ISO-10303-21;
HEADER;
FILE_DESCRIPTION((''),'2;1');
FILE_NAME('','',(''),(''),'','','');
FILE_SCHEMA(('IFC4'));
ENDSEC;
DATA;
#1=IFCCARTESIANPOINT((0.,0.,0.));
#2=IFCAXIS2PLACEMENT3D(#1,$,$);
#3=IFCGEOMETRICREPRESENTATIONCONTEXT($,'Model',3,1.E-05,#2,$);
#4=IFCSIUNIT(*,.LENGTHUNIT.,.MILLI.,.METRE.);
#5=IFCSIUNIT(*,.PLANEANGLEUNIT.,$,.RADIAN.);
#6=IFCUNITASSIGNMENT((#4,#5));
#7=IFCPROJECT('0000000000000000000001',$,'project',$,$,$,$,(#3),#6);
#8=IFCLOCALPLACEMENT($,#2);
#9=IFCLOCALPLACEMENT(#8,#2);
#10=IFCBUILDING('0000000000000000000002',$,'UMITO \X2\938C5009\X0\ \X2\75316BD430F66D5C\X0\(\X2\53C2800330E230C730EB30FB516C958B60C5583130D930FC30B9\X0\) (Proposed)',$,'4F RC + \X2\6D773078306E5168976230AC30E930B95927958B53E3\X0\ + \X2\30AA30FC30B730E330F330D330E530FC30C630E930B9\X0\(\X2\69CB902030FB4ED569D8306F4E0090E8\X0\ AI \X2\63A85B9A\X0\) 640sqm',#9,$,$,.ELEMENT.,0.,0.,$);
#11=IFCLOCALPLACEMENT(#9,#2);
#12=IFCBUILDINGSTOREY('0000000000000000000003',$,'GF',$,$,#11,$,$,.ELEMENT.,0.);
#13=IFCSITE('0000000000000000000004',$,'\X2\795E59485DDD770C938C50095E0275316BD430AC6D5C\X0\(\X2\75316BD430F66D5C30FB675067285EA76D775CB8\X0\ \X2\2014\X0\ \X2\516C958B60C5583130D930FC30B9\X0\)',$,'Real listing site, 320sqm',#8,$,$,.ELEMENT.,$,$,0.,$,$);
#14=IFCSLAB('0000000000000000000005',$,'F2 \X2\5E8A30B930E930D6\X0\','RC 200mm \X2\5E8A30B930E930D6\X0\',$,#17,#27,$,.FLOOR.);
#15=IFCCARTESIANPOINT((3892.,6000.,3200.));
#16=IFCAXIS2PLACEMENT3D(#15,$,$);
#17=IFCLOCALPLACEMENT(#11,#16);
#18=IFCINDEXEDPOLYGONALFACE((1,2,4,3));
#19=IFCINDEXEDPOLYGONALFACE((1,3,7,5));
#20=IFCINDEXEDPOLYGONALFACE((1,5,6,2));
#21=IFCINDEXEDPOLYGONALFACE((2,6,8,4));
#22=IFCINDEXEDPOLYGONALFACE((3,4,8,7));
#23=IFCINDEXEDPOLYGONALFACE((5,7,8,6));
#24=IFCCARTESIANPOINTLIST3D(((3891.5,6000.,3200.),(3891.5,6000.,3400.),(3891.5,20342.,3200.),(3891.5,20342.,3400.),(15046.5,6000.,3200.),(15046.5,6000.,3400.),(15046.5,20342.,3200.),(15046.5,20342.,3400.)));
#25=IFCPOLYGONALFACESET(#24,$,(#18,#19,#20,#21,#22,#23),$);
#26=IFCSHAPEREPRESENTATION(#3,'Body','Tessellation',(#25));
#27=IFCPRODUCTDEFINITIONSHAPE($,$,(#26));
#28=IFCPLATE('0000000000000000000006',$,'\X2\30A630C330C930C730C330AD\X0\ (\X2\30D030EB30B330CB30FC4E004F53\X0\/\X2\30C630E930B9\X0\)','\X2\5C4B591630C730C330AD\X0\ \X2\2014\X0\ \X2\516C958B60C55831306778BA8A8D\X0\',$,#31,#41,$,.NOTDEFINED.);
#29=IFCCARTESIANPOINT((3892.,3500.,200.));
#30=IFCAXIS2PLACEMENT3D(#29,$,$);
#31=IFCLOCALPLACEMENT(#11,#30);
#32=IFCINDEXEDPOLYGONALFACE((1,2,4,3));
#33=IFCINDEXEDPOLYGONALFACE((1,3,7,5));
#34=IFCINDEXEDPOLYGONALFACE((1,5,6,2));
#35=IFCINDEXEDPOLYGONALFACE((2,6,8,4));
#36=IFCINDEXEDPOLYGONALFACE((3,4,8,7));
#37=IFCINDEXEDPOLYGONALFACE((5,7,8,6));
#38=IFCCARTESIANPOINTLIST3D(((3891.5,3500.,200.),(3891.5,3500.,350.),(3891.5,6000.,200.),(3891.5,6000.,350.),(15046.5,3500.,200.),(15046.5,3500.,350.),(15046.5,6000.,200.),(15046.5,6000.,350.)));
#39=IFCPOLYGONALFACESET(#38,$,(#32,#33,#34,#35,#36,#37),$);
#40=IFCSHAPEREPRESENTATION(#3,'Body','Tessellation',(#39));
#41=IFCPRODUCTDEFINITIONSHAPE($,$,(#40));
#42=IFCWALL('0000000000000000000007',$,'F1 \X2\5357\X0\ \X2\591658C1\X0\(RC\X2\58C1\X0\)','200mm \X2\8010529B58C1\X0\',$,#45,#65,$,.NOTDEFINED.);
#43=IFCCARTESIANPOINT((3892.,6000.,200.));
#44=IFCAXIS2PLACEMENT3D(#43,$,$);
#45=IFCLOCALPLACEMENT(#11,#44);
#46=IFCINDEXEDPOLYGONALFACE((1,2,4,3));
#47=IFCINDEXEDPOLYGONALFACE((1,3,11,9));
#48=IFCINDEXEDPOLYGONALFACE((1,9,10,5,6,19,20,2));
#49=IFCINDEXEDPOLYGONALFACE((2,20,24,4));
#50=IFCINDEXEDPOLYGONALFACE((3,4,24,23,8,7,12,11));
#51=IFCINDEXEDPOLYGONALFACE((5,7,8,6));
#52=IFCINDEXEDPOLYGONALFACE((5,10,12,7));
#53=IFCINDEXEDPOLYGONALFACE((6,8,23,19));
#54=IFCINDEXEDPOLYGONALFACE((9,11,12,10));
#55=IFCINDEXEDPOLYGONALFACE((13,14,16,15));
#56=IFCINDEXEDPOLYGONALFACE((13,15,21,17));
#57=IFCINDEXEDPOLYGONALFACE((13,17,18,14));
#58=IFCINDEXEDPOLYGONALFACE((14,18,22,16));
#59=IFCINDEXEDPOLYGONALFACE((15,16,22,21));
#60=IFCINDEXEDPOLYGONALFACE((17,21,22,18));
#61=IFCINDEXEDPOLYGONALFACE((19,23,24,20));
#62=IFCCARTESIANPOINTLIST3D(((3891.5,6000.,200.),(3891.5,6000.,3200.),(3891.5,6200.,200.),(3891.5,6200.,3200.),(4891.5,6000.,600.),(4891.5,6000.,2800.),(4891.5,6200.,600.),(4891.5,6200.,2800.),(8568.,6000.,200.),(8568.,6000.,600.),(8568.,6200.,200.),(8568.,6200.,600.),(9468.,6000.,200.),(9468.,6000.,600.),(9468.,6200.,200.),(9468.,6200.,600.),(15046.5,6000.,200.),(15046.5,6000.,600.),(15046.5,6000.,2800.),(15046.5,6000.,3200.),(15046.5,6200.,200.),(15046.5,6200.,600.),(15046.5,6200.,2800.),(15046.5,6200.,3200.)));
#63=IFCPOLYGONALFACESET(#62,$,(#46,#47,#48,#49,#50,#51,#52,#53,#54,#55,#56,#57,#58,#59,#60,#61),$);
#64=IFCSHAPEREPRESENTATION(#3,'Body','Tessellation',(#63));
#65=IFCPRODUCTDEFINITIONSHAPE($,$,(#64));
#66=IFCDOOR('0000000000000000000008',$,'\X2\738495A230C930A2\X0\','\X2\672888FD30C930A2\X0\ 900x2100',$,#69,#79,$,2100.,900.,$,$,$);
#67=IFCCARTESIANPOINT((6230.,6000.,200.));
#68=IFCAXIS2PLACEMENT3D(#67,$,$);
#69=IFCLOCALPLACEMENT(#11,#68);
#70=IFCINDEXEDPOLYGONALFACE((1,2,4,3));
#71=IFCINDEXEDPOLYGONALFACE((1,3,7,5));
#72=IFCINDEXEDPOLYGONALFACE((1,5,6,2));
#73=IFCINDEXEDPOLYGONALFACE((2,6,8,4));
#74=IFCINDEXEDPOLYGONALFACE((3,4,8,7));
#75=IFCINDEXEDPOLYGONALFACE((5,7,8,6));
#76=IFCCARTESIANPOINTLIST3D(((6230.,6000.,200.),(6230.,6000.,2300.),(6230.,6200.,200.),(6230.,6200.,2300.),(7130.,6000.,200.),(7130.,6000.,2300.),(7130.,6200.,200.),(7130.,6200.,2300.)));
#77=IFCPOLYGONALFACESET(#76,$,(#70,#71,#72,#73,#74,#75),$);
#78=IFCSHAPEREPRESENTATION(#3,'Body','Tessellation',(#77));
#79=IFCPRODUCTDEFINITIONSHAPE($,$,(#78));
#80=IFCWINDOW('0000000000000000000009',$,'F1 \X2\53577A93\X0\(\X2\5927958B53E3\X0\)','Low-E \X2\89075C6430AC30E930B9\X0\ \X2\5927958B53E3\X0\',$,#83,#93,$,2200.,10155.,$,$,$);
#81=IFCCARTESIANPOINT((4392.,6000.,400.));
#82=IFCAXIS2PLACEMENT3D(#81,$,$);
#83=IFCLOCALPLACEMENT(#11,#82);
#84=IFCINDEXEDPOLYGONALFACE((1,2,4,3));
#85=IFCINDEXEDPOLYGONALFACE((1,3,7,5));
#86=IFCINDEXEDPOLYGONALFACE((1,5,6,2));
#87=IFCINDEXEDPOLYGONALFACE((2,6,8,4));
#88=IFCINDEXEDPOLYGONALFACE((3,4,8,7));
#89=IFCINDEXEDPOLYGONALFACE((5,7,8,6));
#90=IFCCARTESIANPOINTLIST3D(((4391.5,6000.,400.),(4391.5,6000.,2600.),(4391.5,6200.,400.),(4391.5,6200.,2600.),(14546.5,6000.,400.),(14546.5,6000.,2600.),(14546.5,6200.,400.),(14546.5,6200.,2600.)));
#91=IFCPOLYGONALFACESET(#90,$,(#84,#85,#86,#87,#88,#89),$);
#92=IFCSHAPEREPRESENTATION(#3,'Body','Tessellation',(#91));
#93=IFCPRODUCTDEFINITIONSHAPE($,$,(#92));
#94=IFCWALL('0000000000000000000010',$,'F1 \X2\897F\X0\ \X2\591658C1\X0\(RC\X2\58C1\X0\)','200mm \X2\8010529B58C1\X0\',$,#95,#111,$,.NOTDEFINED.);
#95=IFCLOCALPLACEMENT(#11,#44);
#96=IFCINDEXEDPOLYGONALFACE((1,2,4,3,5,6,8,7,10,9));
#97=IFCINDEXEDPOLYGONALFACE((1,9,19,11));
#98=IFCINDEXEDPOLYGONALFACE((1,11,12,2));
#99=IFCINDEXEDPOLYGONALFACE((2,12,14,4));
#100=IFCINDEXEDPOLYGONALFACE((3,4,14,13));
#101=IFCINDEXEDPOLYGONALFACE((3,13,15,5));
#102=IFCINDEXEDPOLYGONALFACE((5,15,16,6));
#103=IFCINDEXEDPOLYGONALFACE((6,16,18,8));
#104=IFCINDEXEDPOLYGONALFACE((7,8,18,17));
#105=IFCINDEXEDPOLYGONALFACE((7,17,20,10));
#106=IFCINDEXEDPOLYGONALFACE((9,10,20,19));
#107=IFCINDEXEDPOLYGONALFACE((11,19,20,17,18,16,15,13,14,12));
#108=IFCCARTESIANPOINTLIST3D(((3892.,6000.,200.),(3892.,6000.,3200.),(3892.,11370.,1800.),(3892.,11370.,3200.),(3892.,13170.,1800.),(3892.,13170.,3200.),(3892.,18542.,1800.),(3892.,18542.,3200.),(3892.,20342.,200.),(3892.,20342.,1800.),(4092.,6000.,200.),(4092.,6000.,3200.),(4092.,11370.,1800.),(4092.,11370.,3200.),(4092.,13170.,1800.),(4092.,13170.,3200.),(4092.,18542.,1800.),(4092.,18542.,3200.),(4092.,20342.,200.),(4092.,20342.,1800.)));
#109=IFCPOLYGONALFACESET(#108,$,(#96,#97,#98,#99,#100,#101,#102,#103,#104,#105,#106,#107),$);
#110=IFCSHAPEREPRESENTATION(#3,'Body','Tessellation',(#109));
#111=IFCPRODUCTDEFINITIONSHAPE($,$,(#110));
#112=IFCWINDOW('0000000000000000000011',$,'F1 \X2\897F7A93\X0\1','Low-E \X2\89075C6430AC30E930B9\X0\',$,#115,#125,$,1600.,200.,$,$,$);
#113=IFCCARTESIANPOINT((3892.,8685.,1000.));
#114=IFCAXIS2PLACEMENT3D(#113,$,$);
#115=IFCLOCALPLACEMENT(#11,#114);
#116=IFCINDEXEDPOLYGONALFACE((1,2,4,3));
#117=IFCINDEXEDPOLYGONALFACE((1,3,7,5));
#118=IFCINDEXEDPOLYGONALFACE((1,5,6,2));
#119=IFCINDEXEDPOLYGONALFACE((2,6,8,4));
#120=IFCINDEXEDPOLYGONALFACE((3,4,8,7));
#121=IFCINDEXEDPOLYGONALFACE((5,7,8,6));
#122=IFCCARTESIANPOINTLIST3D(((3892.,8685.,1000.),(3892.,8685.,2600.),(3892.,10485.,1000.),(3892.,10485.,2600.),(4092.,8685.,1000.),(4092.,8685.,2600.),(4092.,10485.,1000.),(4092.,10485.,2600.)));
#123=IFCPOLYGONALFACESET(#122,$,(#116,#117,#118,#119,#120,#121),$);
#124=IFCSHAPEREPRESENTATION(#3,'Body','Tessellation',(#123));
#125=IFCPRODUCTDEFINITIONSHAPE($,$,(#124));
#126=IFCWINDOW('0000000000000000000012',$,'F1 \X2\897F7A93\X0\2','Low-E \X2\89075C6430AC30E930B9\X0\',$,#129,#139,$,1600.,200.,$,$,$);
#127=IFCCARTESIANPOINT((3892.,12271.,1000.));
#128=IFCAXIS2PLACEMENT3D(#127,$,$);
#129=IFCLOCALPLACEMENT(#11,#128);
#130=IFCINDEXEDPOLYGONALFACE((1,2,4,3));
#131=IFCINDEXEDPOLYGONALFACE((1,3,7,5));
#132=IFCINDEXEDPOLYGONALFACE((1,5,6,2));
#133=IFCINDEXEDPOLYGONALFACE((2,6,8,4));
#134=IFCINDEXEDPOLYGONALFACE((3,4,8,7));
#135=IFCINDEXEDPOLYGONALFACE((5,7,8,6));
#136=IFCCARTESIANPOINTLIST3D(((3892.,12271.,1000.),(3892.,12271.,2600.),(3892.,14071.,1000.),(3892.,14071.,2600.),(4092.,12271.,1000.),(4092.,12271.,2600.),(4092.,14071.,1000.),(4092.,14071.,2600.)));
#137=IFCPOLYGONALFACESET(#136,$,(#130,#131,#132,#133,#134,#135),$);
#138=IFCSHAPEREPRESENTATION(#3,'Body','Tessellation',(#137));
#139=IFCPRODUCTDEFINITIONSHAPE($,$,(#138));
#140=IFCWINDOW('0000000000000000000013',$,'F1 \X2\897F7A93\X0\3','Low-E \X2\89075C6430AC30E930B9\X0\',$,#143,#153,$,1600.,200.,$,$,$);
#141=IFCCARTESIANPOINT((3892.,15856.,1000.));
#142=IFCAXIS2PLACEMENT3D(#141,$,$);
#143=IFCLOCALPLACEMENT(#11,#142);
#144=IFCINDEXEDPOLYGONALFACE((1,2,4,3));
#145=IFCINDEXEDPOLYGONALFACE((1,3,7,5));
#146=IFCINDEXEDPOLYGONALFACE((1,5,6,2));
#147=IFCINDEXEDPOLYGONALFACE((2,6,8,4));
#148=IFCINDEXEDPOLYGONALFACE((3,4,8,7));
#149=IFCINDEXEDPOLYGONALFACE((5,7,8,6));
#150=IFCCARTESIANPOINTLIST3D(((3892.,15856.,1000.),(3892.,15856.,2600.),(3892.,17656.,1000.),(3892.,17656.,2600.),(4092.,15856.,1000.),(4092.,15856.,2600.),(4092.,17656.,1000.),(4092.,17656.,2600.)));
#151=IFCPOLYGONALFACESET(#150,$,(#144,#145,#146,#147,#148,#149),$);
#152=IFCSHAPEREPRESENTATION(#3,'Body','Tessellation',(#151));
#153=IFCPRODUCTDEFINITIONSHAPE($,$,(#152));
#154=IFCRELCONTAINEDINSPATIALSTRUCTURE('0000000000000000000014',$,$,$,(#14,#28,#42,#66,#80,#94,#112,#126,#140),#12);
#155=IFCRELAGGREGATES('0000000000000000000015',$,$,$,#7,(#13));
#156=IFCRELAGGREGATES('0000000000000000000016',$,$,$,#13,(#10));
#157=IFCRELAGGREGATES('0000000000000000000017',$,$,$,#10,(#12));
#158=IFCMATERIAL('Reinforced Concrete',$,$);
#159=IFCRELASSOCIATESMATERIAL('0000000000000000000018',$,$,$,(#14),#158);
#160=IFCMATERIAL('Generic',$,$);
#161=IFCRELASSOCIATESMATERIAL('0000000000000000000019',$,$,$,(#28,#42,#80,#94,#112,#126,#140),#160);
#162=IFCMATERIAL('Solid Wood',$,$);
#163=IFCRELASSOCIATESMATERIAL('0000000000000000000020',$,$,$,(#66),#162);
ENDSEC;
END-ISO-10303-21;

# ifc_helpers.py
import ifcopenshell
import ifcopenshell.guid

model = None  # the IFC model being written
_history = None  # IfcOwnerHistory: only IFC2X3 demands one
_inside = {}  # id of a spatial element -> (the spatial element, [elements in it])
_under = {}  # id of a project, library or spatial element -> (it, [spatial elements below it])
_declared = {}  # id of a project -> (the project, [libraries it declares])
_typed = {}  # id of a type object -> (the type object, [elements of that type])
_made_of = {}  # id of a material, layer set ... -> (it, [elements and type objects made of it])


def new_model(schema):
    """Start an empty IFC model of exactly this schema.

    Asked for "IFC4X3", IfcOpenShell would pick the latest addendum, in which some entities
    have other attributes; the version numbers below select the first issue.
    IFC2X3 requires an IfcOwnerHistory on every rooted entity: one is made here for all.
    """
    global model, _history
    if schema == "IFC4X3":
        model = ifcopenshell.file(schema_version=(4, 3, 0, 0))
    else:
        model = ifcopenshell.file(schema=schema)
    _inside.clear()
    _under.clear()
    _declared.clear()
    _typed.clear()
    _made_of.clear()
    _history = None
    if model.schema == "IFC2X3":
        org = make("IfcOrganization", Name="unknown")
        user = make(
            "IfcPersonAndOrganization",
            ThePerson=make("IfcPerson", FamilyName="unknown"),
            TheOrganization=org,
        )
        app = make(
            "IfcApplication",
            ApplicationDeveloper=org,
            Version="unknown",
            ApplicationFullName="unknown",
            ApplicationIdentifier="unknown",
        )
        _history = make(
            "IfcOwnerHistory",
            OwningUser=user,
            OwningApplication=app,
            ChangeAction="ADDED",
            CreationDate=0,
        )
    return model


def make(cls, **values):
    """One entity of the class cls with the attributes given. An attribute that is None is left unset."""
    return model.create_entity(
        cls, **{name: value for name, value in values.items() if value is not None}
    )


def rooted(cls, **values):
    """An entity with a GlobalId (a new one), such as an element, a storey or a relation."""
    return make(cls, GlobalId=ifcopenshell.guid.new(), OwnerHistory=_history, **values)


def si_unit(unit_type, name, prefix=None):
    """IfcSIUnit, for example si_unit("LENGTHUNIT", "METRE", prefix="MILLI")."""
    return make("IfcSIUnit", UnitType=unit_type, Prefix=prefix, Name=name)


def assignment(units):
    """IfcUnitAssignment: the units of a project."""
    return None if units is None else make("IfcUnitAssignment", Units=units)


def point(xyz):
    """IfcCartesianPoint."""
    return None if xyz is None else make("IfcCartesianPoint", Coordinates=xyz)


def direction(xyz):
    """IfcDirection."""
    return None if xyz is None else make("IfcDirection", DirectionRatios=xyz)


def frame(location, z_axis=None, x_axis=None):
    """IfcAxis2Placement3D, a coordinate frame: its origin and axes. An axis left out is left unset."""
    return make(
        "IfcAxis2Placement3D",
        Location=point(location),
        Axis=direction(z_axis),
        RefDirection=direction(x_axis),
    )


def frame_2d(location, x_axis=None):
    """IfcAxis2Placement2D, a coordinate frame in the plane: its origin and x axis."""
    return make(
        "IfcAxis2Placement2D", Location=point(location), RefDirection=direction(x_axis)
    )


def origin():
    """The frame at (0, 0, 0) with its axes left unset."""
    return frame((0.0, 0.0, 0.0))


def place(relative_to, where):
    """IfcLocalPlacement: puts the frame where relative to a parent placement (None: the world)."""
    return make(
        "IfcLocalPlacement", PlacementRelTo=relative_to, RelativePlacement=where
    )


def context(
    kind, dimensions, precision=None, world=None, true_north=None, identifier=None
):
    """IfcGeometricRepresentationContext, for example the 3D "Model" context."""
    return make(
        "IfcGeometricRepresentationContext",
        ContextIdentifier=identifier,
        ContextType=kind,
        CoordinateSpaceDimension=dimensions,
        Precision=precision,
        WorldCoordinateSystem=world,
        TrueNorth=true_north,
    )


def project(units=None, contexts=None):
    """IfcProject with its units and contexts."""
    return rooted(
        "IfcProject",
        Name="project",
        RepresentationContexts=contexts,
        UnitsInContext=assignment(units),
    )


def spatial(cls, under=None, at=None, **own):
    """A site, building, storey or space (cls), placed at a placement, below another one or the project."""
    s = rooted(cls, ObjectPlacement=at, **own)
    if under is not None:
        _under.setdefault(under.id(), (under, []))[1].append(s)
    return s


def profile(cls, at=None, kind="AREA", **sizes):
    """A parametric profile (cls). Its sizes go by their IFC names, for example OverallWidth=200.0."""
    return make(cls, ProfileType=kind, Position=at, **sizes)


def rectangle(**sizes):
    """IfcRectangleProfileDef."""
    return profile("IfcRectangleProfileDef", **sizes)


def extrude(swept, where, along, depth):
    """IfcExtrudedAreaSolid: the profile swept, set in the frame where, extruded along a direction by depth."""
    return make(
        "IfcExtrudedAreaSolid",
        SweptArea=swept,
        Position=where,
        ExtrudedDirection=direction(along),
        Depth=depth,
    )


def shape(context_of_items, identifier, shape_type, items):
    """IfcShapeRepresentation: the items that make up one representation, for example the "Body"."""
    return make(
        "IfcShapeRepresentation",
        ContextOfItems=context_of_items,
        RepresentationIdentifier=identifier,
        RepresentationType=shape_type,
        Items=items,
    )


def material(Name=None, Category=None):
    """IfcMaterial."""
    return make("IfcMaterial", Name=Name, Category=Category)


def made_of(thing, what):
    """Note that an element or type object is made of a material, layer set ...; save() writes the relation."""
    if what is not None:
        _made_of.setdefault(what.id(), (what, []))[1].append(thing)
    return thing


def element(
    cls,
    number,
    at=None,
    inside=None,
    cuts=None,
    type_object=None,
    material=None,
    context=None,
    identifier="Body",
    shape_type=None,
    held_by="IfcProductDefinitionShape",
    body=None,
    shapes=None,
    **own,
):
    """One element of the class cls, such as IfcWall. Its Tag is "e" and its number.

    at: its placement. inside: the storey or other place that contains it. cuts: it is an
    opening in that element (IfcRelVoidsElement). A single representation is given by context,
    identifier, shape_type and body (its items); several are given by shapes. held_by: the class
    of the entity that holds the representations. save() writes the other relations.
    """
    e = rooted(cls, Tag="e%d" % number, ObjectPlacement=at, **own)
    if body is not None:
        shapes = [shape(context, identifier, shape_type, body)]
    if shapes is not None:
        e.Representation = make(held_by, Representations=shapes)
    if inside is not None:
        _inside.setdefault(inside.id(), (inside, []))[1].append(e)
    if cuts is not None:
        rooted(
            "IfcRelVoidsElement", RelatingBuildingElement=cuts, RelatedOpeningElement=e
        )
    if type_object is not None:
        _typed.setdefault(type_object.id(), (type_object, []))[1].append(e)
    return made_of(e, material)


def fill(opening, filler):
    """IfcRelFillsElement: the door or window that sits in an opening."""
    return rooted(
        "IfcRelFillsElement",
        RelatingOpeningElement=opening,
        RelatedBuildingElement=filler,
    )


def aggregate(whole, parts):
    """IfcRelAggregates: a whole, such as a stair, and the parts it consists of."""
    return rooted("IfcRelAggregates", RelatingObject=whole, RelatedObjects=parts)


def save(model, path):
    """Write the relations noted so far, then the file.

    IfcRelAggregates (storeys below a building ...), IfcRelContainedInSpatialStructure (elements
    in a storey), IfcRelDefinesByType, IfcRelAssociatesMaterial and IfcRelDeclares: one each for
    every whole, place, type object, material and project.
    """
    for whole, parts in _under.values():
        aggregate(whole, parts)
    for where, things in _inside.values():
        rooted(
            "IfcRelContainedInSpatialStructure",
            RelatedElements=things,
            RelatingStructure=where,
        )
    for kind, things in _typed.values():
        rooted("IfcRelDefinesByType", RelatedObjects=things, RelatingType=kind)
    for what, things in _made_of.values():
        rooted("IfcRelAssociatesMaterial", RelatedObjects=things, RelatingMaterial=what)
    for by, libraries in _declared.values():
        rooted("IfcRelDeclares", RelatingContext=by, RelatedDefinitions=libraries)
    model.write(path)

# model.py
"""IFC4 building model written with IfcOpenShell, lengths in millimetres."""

from ifc_helpers import new_model, si_unit, frame, frame_2d, origin, place, context, project, spatial, rectangle, extrude, material, element, fill, save


model = new_model("IFC4")

# Units and contexts
model_context = context("Model", 3, precision=1e-05, world=origin())
ifc_project = project(units=[si_unit("LENGTHUNIT", "METRE", prefix="MILLI"), si_unit("PLANEANGLEUNIT", "RADIAN")], contexts=[model_context])

# Site, building, storey
site_placement = place(None, origin())
site = spatial("IfcSite", under=ifc_project, at=site_placement, Name="神奈川県鎌倉市由比ガ浜(由比ヶ浜・材木座海岸 — 公開情報ベース)", ObjectType="Real listing site, 320sqm", CompositionType="ELEMENT", RefElevation=0.0)
building_placement = place(site_placement, origin())
building = spatial("IfcBuilding", under=site, at=building_placement, Name="UMITO 鎌倉 由比ヶ浜(参考モデル・公開情報ベース) (Proposed)", ObjectType="4F RC + 海への全面ガラス大開口 + オーシャンビューテラス(構造・仕様は一部 AI 推定) 640sqm", CompositionType="ELEMENT", ElevationOfRefHeight=0.0, ElevationOfTerrain=0.0)
storey_placement = place(building_placement, origin())
storey = spatial("IfcBuildingStorey", under=building, at=storey_placement, Name="GF", CompositionType="ELEMENT", Elevation=0.0)

# Slab
ifc_material_1 = material(Name="Reinforced Concrete")
slab_1_placement = place(storey_placement, frame((3892.0, 6000.0, 3200.0)))
element("IfcSlab", 1, at=slab_1_placement, inside=storey, material=ifc_material_1, Name="F2 床スラブ", Description="RC 200mm 床スラブ", PredefinedType="FLOOR", context=model_context, shape_type="SweptSolid", body=[
    extrude(rectangle(XDim=11155.0, YDim=14342.0, at=frame_2d((5577.0, 7171.0))), frame((3892.0, 6000.0, 3200.0)), (0.0, 0.0, 1.0), 200.0),
])

# Plate
ifc_material_2 = material(Name="Generic")
plate_placement = place(storey_placement, frame((3892.0, 3500.0, 200.0)))
element("IfcPlate", 2, at=plate_placement, inside=storey, material=ifc_material_2, Name="ウッドデッキ (バルコニー一体/テラス)", Description="屋外デッキ — 公開情報で確認", PredefinedType="NOTDEFINED", context=model_context, shape_type="SweptSolid", body=[
    extrude(rectangle(XDim=11155.0, YDim=2500.0, at=frame_2d((5577.0, 1250.0))), frame((3892.0, 3500.0, 200.0)), (0.0, 0.0, 1.0), 150.0),
])

# Wall, openings, door, window
wall_1_placement = place(storey_placement, frame((3892.0, 6000.0, 200.0)))
wall_1 = element("IfcWall", 3, at=wall_1_placement, inside=storey, material=ifc_material_2, Name="F1 南 外壁(RC壁)", Description="200mm 耐力壁", PredefinedType="NOTDEFINED", context=model_context, shape_type="SweptSolid", body=[
    extrude(rectangle(XDim=11155.0, YDim=200.0, at=frame_2d((5577.0, 100.0))), frame((3892.0, 6000.0, 200.0)), (0.0, 0.0, 1.0), 3000.0),
])
opening_1_placement = place(storey_placement, frame((6230.0, 6000.0, 200.0)))
opening_1 = element("IfcOpeningElement", 4, at=opening_1_placement, cuts=wall_1, PredefinedType="NOTDEFINED", context=model_context, shape_type="SweptSolid", body=[
    extrude(rectangle(XDim=900.0, YDim=200.0, at=frame_2d((450.0, 100.0))), frame((6230.0, 6000.0, 200.0)), (0.0, 0.0, 1.0), 2100.0),
])
opening_2_placement = place(storey_placement, frame((4392.0, 6000.0, 400.0)))
opening_2 = element("IfcOpeningElement", 5, at=opening_2_placement, cuts=wall_1, PredefinedType="NOTDEFINED", context=model_context, shape_type="SweptSolid", body=[
    extrude(rectangle(XDim=10155.0, YDim=200.0, at=frame_2d((5077.0, 100.0))), frame((4392.0, 6000.0, 400.0)), (0.0, 0.0, 1.0), 2200.0),
])
ifc_material_3 = material(Name="Solid Wood")
door_placement = place(storey_placement, frame((6230.0, 6000.0, 200.0)))
door = element("IfcDoor", 6, at=door_placement, inside=storey, material=ifc_material_3, Name="玄関ドア", Description="木製ドア 900x2100", OverallHeight=2100.0, OverallWidth=900.0, context=model_context, shape_type="SweptSolid", body=[
    extrude(rectangle(XDim=900.0, YDim=200.0, at=frame_2d((450.0, 100.0))), frame((6230.0, 6000.0, 200.0)), (0.0, 0.0, 1.0), 2100.0),
])
fill(opening_1, door)
window_1_placement = place(storey_placement, frame((4392.0, 6000.0, 400.0)))
window_1 = element("IfcWindow", 7, at=window_1_placement, inside=storey, material=ifc_material_2, Name="F1 南窓(大開口)", Description="Low-E 複層ガラス 大開口", OverallHeight=2200.0, OverallWidth=10155.0, context=model_context, shape_type="SweptSolid", body=[
    extrude(rectangle(XDim=10155.0, YDim=200.0, at=frame_2d((5077.0, 100.0))), frame((4392.0, 6000.0, 400.0)), (0.0, 0.0, 1.0), 2200.0),
])
fill(opening_2, window_1)

# Wall, openings, windows
wall_2_placement = place(storey_placement, frame((3892.0, 6000.0, 200.0)))
wall_2 = element("IfcWall", 8, at=wall_2_placement, inside=storey, material=ifc_material_2, Name="F1 西 外壁(RC壁)", Description="200mm 耐力壁", PredefinedType="NOTDEFINED", context=model_context, shape_type="SweptSolid", body=[
    extrude(rectangle(XDim=200.0, YDim=14342.0, at=frame_2d((100.0, 7171.0))), frame((3892.0, 6000.0, 200.0)), (0.0, 0.0, 1.0), 3000.0),
])
opening_3_placement = place(storey_placement, frame((3892.0, 8685.0, 1000.0)))
opening_3 = element("IfcOpeningElement", 9, at=opening_3_placement, cuts=wall_2, PredefinedType="NOTDEFINED", context=model_context, shape_type="SweptSolid", body=[
    extrude(rectangle(XDim=200.0, YDim=1800.0, at=frame_2d((100.0, 900.0))), frame((3892.0, 8685.0, 1000.0)), (0.0, 0.0, 1.0), 1600.0),
])
opening_4_placement = place(storey_placement, frame((3892.0, 12271.0, 1000.0)))
opening_4 = element("IfcOpeningElement", 10, at=opening_4_placement, cuts=wall_2, PredefinedType="NOTDEFINED", context=model_context, shape_type="SweptSolid", body=[
    extrude(rectangle(XDim=200.0, YDim=1800.0, at=frame_2d((100.0, 900.0))), frame((3892.0, 12271.0, 1000.0)), (0.0, 0.0, 1.0), 1600.0),
])
opening_5_placement = place(storey_placement, frame((3892.0, 15856.0, 1000.0)))
opening_5 = element("IfcOpeningElement", 11, at=opening_5_placement, cuts=wall_2, PredefinedType="NOTDEFINED", context=model_context, shape_type="SweptSolid", body=[
    extrude(rectangle(XDim=200.0, YDim=1800.0, at=frame_2d((100.0, 900.0))), frame((3892.0, 15856.0, 1000.0)), (0.0, 0.0, 1.0), 1600.0),
])
window_2_placement = place(storey_placement, frame((3892.0, 8685.0, 1000.0)))
window_2 = element("IfcWindow", 12, at=window_2_placement, inside=storey, material=ifc_material_2, Name="F1 西窓1", Description="Low-E 複層ガラス", OverallHeight=1600.0, OverallWidth=200.0, context=model_context, shape_type="SweptSolid", body=[
    extrude(rectangle(XDim=200.0, YDim=1800.0, at=frame_2d((100.0, 900.0))), frame((3892.0, 8685.0, 1000.0)), (0.0, 0.0, 1.0), 1600.0),
])
fill(opening_3, window_2)
window_3_placement = place(storey_placement, frame((3892.0, 12271.0, 1000.0)))
window_3 = element("IfcWindow", 13, at=window_3_placement, inside=storey, material=ifc_material_2, Name="F1 西窓2", Description="Low-E 複層ガラス", OverallHeight=1600.0, OverallWidth=200.0, context=model_context, shape_type="SweptSolid", body=[
    extrude(rectangle(XDim=200.0, YDim=1800.0, at=frame_2d((100.0, 900.0))), frame((3892.0, 12271.0, 1000.0)), (0.0, 0.0, 1.0), 1600.0),
])
fill(opening_4, window_3)
window_4_placement = place(storey_placement, frame((3892.0, 15856.0, 1000.0)))
window_4 = element("IfcWindow", 14, at=window_4_placement, inside=storey, material=ifc_material_2, Name="F1 西窓3", Description="Low-E 複層ガラス", OverallHeight=1600.0, OverallWidth=200.0, context=model_context, shape_type="SweptSolid", body=[
    extrude(rectangle(XDim=200.0, YDim=1800.0, at=frame_2d((100.0, 900.0))), frame((3892.0, 15856.0, 1000.0)), (0.0, 0.0, 1.0), 1600.0),
])
fill(opening_5, window_4)

save(model, "model.ifc")
